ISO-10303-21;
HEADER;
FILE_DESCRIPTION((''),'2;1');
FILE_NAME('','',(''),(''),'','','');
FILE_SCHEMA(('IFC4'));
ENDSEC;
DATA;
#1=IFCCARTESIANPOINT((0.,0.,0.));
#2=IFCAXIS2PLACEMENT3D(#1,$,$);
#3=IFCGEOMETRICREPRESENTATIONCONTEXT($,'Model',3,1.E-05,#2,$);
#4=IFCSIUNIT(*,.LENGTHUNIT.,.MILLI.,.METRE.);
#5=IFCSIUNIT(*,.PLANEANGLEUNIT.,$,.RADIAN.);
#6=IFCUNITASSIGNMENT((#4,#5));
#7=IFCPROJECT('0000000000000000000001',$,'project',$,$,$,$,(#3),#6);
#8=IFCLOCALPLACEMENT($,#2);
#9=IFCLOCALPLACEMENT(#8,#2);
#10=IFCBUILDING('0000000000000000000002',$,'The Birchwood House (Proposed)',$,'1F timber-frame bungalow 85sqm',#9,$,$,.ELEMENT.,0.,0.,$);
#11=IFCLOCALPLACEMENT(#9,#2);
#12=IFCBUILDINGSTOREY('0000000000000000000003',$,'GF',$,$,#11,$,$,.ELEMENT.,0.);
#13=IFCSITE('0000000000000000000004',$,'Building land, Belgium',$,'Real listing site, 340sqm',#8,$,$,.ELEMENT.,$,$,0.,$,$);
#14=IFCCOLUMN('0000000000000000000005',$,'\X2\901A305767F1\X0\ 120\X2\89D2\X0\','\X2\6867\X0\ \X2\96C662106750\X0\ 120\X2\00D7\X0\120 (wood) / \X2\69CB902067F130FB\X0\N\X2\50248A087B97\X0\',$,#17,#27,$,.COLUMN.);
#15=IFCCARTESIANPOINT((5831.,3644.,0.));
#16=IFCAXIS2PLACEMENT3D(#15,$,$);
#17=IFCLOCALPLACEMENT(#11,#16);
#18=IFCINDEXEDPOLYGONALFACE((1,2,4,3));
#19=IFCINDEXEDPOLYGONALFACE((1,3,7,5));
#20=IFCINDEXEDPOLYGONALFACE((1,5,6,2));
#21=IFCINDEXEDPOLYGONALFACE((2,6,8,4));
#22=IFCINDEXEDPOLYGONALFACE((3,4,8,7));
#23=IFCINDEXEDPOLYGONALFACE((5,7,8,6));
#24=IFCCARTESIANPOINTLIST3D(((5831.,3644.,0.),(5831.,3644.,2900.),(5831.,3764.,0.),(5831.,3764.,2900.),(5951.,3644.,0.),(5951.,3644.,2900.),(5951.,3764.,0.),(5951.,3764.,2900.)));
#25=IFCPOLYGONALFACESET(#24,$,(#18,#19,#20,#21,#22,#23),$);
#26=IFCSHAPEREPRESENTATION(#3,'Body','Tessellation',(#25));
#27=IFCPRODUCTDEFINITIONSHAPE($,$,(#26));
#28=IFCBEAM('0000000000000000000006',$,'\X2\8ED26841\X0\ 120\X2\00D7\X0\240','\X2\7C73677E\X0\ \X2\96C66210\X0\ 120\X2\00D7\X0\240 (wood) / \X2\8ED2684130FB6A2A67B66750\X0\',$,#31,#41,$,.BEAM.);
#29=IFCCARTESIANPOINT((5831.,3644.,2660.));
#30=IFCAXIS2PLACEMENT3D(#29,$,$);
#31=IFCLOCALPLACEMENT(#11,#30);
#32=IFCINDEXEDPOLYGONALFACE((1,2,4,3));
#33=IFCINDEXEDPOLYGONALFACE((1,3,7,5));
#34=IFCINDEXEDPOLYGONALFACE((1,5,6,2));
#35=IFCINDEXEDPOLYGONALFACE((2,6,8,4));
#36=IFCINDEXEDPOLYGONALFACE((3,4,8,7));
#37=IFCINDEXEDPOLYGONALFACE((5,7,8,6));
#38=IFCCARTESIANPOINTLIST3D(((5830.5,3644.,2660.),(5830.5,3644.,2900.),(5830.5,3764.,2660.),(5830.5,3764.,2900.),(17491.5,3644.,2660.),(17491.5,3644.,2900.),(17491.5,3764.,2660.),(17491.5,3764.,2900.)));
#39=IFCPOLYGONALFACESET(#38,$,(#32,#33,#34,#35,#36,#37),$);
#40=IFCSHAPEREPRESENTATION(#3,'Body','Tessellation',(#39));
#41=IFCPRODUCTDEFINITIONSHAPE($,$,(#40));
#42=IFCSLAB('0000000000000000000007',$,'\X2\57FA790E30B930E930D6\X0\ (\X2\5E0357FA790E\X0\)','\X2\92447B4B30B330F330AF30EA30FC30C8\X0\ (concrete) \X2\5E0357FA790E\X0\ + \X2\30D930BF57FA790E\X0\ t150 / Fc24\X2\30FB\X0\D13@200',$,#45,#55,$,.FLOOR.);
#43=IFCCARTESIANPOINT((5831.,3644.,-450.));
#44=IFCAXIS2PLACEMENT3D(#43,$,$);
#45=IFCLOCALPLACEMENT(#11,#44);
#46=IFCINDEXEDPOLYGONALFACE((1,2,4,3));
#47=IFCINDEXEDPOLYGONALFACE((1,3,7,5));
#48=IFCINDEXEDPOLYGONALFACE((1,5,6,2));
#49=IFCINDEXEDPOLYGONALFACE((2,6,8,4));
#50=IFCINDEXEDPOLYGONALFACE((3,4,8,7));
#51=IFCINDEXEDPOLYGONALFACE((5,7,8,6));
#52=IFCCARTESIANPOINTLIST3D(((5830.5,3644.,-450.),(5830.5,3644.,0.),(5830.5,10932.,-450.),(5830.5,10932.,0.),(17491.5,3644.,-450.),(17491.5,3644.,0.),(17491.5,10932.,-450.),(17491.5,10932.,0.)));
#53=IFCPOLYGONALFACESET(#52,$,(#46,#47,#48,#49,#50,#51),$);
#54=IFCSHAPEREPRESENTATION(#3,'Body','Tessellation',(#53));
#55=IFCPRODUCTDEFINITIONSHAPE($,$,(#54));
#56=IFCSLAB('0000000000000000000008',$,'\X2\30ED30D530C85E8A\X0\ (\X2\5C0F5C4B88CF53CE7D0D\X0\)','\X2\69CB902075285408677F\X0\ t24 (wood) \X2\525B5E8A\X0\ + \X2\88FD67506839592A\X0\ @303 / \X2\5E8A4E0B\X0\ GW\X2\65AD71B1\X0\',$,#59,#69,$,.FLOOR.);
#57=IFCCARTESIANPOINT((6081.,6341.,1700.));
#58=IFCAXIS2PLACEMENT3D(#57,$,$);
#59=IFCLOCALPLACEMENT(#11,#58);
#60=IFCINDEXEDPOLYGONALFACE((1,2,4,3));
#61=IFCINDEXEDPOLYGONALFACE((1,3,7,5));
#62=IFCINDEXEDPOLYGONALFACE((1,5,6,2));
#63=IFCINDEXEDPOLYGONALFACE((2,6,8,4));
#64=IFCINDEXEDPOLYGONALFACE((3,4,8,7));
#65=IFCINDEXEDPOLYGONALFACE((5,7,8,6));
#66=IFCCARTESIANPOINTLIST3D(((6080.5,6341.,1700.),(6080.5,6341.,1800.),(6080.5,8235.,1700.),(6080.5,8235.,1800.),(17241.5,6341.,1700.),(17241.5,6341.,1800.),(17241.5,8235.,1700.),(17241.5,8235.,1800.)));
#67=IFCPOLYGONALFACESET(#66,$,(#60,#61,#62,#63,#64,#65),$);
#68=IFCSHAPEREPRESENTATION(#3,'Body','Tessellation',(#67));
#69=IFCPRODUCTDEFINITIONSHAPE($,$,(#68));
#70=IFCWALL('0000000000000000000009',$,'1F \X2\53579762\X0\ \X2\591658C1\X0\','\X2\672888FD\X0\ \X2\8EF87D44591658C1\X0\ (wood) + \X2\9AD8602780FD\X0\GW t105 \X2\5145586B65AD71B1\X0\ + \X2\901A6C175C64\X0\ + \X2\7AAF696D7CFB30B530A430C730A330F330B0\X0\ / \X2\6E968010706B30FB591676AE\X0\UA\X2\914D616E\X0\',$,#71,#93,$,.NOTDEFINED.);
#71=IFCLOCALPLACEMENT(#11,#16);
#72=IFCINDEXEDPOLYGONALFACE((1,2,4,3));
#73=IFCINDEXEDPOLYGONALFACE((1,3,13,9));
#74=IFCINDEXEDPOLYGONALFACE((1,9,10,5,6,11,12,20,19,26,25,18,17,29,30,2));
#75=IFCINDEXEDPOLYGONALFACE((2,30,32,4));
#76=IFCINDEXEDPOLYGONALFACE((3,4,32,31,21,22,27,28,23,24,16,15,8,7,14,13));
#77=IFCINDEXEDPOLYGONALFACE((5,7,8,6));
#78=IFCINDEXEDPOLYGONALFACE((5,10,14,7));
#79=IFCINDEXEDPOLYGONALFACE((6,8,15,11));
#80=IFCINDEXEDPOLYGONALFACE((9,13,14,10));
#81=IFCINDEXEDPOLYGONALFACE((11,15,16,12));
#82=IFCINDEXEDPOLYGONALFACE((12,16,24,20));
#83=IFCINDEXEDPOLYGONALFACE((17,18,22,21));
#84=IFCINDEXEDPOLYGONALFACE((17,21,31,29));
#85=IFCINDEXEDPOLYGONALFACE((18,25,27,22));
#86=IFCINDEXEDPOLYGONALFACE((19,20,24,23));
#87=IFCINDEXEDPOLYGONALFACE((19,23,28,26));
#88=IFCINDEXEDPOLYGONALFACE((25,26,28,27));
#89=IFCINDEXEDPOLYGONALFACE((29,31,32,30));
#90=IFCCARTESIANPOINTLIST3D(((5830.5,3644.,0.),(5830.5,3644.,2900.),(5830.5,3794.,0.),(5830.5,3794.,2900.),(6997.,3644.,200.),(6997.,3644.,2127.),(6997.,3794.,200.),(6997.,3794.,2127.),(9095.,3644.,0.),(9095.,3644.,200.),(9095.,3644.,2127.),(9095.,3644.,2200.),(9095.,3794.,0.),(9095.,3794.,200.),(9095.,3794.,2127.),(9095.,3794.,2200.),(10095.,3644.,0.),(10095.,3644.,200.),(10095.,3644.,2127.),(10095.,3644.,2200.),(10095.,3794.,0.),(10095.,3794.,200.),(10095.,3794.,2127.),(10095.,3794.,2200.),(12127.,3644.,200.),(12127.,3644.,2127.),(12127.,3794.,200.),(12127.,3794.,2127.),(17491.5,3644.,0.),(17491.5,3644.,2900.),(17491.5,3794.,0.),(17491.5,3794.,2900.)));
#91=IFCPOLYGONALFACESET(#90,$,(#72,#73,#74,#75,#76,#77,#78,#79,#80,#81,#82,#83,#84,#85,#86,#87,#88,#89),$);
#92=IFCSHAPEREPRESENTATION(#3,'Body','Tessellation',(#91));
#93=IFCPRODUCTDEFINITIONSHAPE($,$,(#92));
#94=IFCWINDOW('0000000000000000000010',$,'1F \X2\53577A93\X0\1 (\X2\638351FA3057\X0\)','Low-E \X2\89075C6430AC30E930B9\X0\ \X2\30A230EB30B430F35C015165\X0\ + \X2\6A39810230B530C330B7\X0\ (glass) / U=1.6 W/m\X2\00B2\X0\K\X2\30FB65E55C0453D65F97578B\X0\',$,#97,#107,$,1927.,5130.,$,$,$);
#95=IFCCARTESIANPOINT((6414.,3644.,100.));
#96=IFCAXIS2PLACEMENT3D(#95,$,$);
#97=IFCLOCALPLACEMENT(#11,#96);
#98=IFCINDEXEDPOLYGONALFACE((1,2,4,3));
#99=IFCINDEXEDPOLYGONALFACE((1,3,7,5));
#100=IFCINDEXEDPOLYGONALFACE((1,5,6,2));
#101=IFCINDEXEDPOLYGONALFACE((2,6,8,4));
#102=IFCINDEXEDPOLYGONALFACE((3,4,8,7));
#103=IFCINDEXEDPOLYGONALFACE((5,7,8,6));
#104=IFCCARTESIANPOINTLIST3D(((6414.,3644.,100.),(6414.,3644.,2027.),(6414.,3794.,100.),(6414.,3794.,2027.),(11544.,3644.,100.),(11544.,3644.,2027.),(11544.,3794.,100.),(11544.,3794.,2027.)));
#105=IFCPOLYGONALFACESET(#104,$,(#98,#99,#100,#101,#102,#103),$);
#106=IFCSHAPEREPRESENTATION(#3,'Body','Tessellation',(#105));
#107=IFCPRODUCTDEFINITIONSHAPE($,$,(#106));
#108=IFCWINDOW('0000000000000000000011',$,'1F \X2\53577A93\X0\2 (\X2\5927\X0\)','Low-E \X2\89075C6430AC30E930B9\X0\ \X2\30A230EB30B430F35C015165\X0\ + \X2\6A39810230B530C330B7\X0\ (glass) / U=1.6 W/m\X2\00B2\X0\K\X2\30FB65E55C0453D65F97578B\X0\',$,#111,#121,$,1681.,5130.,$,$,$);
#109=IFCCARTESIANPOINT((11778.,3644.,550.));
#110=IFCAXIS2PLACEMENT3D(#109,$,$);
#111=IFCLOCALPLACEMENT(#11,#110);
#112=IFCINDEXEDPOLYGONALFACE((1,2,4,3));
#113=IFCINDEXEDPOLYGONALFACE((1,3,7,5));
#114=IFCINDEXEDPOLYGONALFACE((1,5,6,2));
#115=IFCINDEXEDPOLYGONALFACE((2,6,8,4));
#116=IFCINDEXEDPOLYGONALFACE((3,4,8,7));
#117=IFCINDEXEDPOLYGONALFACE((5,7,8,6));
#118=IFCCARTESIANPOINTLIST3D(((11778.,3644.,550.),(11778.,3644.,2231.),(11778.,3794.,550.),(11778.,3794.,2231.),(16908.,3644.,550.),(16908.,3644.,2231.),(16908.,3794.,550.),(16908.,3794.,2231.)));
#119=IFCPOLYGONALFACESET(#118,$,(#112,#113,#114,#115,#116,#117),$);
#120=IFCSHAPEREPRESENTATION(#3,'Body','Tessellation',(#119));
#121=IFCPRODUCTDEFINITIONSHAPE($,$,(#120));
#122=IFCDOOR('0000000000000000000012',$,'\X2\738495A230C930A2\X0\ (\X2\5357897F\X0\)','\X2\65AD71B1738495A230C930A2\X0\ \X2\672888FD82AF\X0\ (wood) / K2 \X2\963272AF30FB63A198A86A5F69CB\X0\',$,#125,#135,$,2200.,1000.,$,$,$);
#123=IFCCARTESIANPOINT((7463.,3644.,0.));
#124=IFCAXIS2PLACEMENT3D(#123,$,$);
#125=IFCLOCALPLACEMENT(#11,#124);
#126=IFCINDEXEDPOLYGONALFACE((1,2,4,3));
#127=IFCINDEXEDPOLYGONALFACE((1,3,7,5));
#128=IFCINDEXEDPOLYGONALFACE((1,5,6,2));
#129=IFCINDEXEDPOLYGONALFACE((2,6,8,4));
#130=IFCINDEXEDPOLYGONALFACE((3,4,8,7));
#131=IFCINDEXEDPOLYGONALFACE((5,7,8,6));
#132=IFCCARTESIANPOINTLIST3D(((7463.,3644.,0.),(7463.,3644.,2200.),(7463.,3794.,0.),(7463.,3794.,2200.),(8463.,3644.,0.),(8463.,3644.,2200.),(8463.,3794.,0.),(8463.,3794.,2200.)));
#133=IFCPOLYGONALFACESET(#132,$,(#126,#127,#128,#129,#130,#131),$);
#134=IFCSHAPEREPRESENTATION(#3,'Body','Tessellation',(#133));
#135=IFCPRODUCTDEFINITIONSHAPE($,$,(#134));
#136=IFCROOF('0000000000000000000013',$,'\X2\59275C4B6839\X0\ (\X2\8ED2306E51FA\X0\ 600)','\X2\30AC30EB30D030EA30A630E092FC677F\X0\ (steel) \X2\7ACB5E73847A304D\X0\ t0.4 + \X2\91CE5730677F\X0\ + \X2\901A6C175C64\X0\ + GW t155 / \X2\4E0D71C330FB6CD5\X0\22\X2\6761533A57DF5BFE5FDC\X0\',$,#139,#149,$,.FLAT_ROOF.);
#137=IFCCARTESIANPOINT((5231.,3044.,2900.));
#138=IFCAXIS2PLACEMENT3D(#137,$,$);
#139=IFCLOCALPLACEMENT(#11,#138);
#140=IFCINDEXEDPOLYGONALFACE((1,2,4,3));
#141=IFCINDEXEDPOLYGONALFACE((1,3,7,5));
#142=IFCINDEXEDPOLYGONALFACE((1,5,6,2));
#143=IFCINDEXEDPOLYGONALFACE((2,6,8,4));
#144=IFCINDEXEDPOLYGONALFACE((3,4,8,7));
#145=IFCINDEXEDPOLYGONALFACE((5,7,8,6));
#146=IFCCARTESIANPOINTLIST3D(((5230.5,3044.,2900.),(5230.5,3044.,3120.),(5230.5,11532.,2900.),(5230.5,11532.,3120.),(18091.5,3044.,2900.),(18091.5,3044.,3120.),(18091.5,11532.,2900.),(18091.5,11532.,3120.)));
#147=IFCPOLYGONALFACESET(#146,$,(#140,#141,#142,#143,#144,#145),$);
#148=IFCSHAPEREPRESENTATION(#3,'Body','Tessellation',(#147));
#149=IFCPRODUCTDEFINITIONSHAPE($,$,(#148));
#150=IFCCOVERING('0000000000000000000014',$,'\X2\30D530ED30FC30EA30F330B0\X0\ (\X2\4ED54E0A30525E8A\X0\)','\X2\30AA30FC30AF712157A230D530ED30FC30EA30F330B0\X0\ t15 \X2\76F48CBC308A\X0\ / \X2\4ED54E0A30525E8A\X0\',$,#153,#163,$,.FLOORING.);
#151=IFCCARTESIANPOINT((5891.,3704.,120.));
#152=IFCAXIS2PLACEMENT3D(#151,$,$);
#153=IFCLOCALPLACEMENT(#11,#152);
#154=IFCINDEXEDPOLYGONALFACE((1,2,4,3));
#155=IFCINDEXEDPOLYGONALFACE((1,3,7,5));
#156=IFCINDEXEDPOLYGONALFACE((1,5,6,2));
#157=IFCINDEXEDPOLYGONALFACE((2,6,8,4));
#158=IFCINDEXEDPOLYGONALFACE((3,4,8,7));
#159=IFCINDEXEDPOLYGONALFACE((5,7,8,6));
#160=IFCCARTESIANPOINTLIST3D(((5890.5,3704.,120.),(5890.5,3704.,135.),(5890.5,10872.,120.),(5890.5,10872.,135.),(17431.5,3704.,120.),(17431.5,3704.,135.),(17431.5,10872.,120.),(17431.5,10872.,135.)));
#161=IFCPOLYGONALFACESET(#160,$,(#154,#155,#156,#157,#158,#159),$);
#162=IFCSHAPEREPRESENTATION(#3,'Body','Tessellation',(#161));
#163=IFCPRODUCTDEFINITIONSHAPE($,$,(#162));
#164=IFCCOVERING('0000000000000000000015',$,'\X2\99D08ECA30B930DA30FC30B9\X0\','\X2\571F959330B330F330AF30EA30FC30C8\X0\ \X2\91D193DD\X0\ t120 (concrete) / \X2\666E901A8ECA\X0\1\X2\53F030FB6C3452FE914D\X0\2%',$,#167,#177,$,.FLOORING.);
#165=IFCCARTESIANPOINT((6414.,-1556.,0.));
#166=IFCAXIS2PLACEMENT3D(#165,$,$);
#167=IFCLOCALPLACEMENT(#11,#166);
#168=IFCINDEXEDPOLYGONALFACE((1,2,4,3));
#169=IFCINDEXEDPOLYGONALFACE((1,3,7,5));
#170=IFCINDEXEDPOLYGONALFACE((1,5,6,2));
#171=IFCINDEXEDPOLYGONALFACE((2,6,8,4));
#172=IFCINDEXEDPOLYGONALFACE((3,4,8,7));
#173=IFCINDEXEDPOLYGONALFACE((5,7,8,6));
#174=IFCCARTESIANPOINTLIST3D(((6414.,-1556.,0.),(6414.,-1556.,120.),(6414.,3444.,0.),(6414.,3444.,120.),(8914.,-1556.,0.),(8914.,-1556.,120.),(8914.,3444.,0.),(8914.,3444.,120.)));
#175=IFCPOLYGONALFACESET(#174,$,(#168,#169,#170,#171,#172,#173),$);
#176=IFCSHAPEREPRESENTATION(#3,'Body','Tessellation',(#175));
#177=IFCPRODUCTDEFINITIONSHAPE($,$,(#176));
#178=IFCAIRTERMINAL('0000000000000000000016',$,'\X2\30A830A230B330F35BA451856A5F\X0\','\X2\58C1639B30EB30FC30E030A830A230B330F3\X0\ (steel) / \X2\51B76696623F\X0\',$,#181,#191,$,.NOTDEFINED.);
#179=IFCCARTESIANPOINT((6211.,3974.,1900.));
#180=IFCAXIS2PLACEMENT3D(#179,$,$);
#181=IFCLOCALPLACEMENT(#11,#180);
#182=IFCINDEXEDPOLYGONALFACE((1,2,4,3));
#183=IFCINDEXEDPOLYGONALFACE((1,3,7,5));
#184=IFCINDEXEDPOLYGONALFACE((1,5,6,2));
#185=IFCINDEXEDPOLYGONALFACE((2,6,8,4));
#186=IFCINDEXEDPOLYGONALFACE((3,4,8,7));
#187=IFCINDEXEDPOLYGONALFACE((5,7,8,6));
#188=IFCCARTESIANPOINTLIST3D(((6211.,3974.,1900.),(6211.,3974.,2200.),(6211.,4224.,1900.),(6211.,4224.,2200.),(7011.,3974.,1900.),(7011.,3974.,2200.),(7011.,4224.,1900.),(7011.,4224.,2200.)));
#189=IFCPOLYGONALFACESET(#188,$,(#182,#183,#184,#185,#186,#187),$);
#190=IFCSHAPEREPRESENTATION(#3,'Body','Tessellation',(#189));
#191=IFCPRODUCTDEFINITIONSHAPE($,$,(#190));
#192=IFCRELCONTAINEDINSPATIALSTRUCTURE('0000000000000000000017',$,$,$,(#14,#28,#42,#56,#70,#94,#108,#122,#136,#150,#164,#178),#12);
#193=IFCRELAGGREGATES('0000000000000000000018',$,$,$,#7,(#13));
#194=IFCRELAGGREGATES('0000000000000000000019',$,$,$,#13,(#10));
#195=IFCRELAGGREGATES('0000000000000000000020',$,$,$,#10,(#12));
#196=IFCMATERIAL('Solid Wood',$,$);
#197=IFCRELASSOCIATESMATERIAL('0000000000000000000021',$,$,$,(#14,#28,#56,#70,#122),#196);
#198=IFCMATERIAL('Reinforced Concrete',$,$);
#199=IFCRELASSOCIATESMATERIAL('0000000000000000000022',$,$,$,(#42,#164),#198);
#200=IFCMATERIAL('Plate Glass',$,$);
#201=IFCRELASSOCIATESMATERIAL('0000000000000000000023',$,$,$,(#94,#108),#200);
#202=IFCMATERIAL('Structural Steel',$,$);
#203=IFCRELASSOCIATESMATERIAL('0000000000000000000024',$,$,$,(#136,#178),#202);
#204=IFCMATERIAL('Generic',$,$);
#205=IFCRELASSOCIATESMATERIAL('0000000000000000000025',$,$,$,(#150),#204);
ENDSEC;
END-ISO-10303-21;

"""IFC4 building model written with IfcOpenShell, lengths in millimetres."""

from ifc_helpers import new_model, si_unit, frame, frame_2d, origin, place, context, project, spatial, rectangle, extrude, material, element, fill, save


model = new_model("IFC4")

# Units and contexts
model_context = context("Model", 3, precision=1e-05, world=origin())
ifc_project = project(units=[si_unit("LENGTHUNIT", "METRE", prefix="MILLI"), si_unit("PLANEANGLEUNIT", "RADIAN")], contexts=[model_context])

# Site, building, storey
site_placement = place(None, origin())
site = spatial("IfcSite", under=ifc_project, at=site_placement, Name="Building land, Belgium", ObjectType="Real listing site, 340sqm", CompositionType="ELEMENT", RefElevation=0.0)
building_placement = place(site_placement, origin())
building = spatial("IfcBuilding", under=site, at=building_placement, Name="The Birchwood House (Proposed)", ObjectType="1F timber-frame bungalow 85sqm", CompositionType="ELEMENT", ElevationOfRefHeight=0.0, ElevationOfTerrain=0.0)
storey_placement = place(building_placement, origin())
storey = spatial("IfcBuildingStorey", under=building, at=storey_placement, Name="GF", CompositionType="ELEMENT", Elevation=0.0)

# Column
ifc_material_1 = material(Name="Solid Wood")
column_1_placement = place(storey_placement, frame((5831.0, 3644.0, 0.0)))
element("IfcColumn", 1, at=column_1_placement, inside=storey, material=ifc_material_1, Name="通し柱 120角", Description="桧 集成材 120×120 (wood) / 構造柱・N値計算", PredefinedType="COLUMN", context=model_context, shape_type="SweptSolid", body=[
    extrude(rectangle(XDim=120.0, YDim=120.0, at=frame_2d((60.0, 60.0))), frame((5831.0, 3644.0, 0.0)), (0.0, 0.0, 1.0), 2900.0),
])

# Beam
beam_1_placement = place(storey_placement, frame((5831.0, 3644.0, 2660.0)))
element("IfcBeam", 2, at=beam_1_placement, inside=storey, material=ifc_material_1, Name="軒桁 120×240", Description="米松 集成 120×240 (wood) / 軒桁・横架材", PredefinedType="BEAM", context=model_context, shape_type="SweptSolid", body=[
    extrude(rectangle(XDim=11661.0, YDim=120.0, at=frame_2d((5830.0, 60.0))), frame((5831.0, 3644.0, 2660.0)), (0.0, 0.0, 1.0), 240.0),
])

# Slabs
ifc_material_2 = material(Name="Reinforced Concrete")
slab_1_placement = place(storey_placement, frame((5831.0, 3644.0, -450.0)))
element("IfcSlab", 3, at=slab_1_placement, inside=storey, material=ifc_material_2, Name="基礎スラブ (布基礎)", Description="鉄筋コンクリート (concrete) 布基礎 + ベタ基礎 t150 / Fc24・D13@200", PredefinedType="FLOOR", context=model_context, shape_type="SweptSolid", body=[
    extrude(rectangle(XDim=11661.0, YDim=7288.0, at=frame_2d((5830.0, 3644.0))), frame((5831.0, 3644.0, -450.0)), (0.0, 0.0, 1.0), 450.0),
])
slab_2_placement = place(storey_placement, frame((6081.0, 6341.0, 1700.0)))
element("IfcSlab", 4, at=slab_2_placement, inside=storey, material=ifc_material_1, Name="ロフト床 (小屋裏収納)", Description="構造用合板 t24 (wood) 剛床 + 製材根太 @303 / 床下 GW断熱", PredefinedType="FLOOR", context=model_context, shape_type="SweptSolid", body=[
    extrude(rectangle(XDim=11161.0, YDim=1894.0, at=frame_2d((5580.0, 947.0))), frame((6081.0, 6341.0, 1700.0)), (0.0, 0.0, 1.0), 100.0),
])

# Wall, openings, windows, door
wall_1_placement = place(storey_placement, frame((5831.0, 3644.0, 0.0)))
wall_1 = element("IfcWall", 5, at=wall_1_placement, inside=storey, material=ifc_material_1, Name="1F 南面 外壁", Description="木製 軸組外壁 (wood) + 高性能GW t105 充填断熱 + 通気層 + 窯業系サイディング / 準耐火・外皮UA配慮", PredefinedType="NOTDEFINED", context=model_context, shape_type="SweptSolid", body=[
    extrude(rectangle(XDim=11661.0, YDim=150.0, at=frame_2d((5830.0, 75.0))), frame((5831.0, 3644.0, 0.0)), (0.0, 0.0, 1.0), 2900.0),
])
opening_1_placement = place(storey_placement, frame((6414.0, 3644.0, 100.0)))
opening_1 = element("IfcOpeningElement", 6, at=opening_1_placement, cuts=wall_1, PredefinedType="NOTDEFINED", context=model_context, shape_type="SweptSolid", body=[
    extrude(rectangle(XDim=5130.0, YDim=150.0, at=frame_2d((2565.0, 75.0))), frame((6414.0, 3644.0, 100.0)), (0.0, 0.0, 1.0), 1927.0),
])
opening_2_placement = place(storey_placement, frame((11778.0, 3644.0, 550.0)))
opening_2 = element("IfcOpeningElement", 7, at=opening_2_placement, cuts=wall_1, PredefinedType="NOTDEFINED", context=model_context, shape_type="SweptSolid", body=[
    extrude(rectangle(XDim=5130.0, YDim=150.0, at=frame_2d((2565.0, 75.0))), frame((11778.0, 3644.0, 550.0)), (0.0, 0.0, 1.0), 1681.0),
])
opening_3_placement = place(storey_placement, frame((7463.0, 3644.0, 0.0)))
opening_3 = element("IfcOpeningElement", 8, at=opening_3_placement, cuts=wall_1, PredefinedType="NOTDEFINED", context=model_context, shape_type="SweptSolid", body=[
    extrude(rectangle(XDim=1000.0, YDim=150.0, at=frame_2d((500.0, 75.0))), frame((7463.0, 3644.0, 0.0)), (0.0, 0.0, 1.0), 2200.0),
])
ifc_material_3 = material(Name="Plate Glass")
window_1_placement = place(storey_placement, frame((6414.0, 3644.0, 100.0)))
window_1 = element("IfcWindow", 9, at=window_1_placement, inside=storey, material=ifc_material_3, Name="1F 南窓1 (掃出し)", Description="Low-E 複層ガラス アルゴン封入 + 樹脂サッシ (glass) / U=1.6 W/m²K・日射取得型", OverallHeight=1927.0, OverallWidth=5130.0, context=model_context, shape_type="SweptSolid", body=[
    extrude(rectangle(XDim=5130.0, YDim=150.0, at=frame_2d((2565.0, 75.0))), frame((6414.0, 3644.0, 100.0)), (0.0, 0.0, 1.0), 1927.0),
])
fill(opening_1, window_1)
window_2_placement = place(storey_placement, frame((11778.0, 3644.0, 550.0)))
window_2 = element("IfcWindow", 10, at=window_2_placement, inside=storey, material=ifc_material_3, Name="1F 南窓2 (大)", Description="Low-E 複層ガラス アルゴン封入 + 樹脂サッシ (glass) / U=1.6 W/m²K・日射取得型", OverallHeight=1681.0, OverallWidth=5130.0, context=model_context, shape_type="SweptSolid", body=[
    extrude(rectangle(XDim=5130.0, YDim=150.0, at=frame_2d((2565.0, 75.0))), frame((11778.0, 3644.0, 550.0)), (0.0, 0.0, 1.0), 1681.0),
])
fill(opening_2, window_2)
door_placement = place(storey_placement, frame((7463.0, 3644.0, 0.0)))
door = element("IfcDoor", 11, at=door_placement, inside=storey, material=ifc_material_1, Name="玄関ドア (南西)", Description="断熱玄関ドア 木製芯 (wood) / K2 防犯・採風機構", OverallHeight=2200.0, OverallWidth=1000.0, context=model_context, shape_type="SweptSolid", body=[
    extrude(rectangle(XDim=1000.0, YDim=150.0, at=frame_2d((500.0, 75.0))), frame((7463.0, 3644.0, 0.0)), (0.0, 0.0, 1.0), 2200.0),
])
fill(opening_3, door)

# Roof
ifc_material_4 = material(Name="Structural Steel")
roof_placement = place(storey_placement, frame((5231.0, 3044.0, 2900.0)))
element("IfcRoof", 12, at=roof_placement, inside=storey, material=ifc_material_4, Name="大屋根 (軒の出 600)", Description="ガルバリウム鋼板 (steel) 立平葺き t0.4 + 野地板 + 通気層 + GW t155 / 不燃・法22条区域対応", PredefinedType="FLAT_ROOF", context=model_context, shape_type="SweptSolid", body=[
    extrude(rectangle(XDim=12861.0, YDim=8488.0, at=frame_2d((6430.0, 4244.0))), frame((5231.0, 3044.0, 2900.0)), (0.0, 0.0, 1.0), 220.0),
])

# Coverings
ifc_material_5 = material(Name="Generic")
covering_1_placement = place(storey_placement, frame((5891.0, 3704.0, 120.0)))
element("IfcCovering", 13, at=covering_1_placement, inside=storey, material=ifc_material_5, Name="フローリング (仕上げ床)", Description="オーク無垢フローリング t15 直貼り / 仕上げ床", PredefinedType="FLOORING", context=model_context, shape_type="SweptSolid", body=[
    extrude(rectangle(XDim=11541.0, YDim=7168.0, at=frame_2d((5770.0, 3584.0))), frame((5891.0, 3704.0, 120.0)), (0.0, 0.0, 1.0), 15.0),
])
covering_2_placement = place(storey_placement, frame((6414.0, -1556.0, 0.0)))
element("IfcCovering", 14, at=covering_2_placement, inside=storey, material=ifc_material_2, Name="駐車スペース", Description="土間コンクリート 金鏝 t120 (concrete) / 普通車1台・水勾配2%", PredefinedType="FLOORING", context=model_context, shape_type="SweptSolid", body=[
    extrude(rectangle(XDim=2500.0, YDim=5000.0, at=frame_2d((1250.0, 2500.0))), frame((6414.0, -1556.0, 0.0)), (0.0, 0.0, 1.0), 120.0),
])

# Air terminal
air_terminal_placement = place(storey_placement, frame((6211.0, 3974.0, 1900.0)))
element("IfcAirTerminal", 15, at=air_terminal_placement, inside=storey, material=ifc_material_4, Name="エアコン室内機", Description="壁掛ルームエアコン (steel) / 冷暖房", PredefinedType="NOTDEFINED", context=model_context, shape_type="SweptSolid", body=[
    extrude(rectangle(XDim=800.0, YDim=250.0, at=frame_2d((400.0, 125.0))), frame((6211.0, 3974.0, 1900.0)), (0.0, 0.0, 1.0), 300.0),
])

save(model, "model.ifc")
